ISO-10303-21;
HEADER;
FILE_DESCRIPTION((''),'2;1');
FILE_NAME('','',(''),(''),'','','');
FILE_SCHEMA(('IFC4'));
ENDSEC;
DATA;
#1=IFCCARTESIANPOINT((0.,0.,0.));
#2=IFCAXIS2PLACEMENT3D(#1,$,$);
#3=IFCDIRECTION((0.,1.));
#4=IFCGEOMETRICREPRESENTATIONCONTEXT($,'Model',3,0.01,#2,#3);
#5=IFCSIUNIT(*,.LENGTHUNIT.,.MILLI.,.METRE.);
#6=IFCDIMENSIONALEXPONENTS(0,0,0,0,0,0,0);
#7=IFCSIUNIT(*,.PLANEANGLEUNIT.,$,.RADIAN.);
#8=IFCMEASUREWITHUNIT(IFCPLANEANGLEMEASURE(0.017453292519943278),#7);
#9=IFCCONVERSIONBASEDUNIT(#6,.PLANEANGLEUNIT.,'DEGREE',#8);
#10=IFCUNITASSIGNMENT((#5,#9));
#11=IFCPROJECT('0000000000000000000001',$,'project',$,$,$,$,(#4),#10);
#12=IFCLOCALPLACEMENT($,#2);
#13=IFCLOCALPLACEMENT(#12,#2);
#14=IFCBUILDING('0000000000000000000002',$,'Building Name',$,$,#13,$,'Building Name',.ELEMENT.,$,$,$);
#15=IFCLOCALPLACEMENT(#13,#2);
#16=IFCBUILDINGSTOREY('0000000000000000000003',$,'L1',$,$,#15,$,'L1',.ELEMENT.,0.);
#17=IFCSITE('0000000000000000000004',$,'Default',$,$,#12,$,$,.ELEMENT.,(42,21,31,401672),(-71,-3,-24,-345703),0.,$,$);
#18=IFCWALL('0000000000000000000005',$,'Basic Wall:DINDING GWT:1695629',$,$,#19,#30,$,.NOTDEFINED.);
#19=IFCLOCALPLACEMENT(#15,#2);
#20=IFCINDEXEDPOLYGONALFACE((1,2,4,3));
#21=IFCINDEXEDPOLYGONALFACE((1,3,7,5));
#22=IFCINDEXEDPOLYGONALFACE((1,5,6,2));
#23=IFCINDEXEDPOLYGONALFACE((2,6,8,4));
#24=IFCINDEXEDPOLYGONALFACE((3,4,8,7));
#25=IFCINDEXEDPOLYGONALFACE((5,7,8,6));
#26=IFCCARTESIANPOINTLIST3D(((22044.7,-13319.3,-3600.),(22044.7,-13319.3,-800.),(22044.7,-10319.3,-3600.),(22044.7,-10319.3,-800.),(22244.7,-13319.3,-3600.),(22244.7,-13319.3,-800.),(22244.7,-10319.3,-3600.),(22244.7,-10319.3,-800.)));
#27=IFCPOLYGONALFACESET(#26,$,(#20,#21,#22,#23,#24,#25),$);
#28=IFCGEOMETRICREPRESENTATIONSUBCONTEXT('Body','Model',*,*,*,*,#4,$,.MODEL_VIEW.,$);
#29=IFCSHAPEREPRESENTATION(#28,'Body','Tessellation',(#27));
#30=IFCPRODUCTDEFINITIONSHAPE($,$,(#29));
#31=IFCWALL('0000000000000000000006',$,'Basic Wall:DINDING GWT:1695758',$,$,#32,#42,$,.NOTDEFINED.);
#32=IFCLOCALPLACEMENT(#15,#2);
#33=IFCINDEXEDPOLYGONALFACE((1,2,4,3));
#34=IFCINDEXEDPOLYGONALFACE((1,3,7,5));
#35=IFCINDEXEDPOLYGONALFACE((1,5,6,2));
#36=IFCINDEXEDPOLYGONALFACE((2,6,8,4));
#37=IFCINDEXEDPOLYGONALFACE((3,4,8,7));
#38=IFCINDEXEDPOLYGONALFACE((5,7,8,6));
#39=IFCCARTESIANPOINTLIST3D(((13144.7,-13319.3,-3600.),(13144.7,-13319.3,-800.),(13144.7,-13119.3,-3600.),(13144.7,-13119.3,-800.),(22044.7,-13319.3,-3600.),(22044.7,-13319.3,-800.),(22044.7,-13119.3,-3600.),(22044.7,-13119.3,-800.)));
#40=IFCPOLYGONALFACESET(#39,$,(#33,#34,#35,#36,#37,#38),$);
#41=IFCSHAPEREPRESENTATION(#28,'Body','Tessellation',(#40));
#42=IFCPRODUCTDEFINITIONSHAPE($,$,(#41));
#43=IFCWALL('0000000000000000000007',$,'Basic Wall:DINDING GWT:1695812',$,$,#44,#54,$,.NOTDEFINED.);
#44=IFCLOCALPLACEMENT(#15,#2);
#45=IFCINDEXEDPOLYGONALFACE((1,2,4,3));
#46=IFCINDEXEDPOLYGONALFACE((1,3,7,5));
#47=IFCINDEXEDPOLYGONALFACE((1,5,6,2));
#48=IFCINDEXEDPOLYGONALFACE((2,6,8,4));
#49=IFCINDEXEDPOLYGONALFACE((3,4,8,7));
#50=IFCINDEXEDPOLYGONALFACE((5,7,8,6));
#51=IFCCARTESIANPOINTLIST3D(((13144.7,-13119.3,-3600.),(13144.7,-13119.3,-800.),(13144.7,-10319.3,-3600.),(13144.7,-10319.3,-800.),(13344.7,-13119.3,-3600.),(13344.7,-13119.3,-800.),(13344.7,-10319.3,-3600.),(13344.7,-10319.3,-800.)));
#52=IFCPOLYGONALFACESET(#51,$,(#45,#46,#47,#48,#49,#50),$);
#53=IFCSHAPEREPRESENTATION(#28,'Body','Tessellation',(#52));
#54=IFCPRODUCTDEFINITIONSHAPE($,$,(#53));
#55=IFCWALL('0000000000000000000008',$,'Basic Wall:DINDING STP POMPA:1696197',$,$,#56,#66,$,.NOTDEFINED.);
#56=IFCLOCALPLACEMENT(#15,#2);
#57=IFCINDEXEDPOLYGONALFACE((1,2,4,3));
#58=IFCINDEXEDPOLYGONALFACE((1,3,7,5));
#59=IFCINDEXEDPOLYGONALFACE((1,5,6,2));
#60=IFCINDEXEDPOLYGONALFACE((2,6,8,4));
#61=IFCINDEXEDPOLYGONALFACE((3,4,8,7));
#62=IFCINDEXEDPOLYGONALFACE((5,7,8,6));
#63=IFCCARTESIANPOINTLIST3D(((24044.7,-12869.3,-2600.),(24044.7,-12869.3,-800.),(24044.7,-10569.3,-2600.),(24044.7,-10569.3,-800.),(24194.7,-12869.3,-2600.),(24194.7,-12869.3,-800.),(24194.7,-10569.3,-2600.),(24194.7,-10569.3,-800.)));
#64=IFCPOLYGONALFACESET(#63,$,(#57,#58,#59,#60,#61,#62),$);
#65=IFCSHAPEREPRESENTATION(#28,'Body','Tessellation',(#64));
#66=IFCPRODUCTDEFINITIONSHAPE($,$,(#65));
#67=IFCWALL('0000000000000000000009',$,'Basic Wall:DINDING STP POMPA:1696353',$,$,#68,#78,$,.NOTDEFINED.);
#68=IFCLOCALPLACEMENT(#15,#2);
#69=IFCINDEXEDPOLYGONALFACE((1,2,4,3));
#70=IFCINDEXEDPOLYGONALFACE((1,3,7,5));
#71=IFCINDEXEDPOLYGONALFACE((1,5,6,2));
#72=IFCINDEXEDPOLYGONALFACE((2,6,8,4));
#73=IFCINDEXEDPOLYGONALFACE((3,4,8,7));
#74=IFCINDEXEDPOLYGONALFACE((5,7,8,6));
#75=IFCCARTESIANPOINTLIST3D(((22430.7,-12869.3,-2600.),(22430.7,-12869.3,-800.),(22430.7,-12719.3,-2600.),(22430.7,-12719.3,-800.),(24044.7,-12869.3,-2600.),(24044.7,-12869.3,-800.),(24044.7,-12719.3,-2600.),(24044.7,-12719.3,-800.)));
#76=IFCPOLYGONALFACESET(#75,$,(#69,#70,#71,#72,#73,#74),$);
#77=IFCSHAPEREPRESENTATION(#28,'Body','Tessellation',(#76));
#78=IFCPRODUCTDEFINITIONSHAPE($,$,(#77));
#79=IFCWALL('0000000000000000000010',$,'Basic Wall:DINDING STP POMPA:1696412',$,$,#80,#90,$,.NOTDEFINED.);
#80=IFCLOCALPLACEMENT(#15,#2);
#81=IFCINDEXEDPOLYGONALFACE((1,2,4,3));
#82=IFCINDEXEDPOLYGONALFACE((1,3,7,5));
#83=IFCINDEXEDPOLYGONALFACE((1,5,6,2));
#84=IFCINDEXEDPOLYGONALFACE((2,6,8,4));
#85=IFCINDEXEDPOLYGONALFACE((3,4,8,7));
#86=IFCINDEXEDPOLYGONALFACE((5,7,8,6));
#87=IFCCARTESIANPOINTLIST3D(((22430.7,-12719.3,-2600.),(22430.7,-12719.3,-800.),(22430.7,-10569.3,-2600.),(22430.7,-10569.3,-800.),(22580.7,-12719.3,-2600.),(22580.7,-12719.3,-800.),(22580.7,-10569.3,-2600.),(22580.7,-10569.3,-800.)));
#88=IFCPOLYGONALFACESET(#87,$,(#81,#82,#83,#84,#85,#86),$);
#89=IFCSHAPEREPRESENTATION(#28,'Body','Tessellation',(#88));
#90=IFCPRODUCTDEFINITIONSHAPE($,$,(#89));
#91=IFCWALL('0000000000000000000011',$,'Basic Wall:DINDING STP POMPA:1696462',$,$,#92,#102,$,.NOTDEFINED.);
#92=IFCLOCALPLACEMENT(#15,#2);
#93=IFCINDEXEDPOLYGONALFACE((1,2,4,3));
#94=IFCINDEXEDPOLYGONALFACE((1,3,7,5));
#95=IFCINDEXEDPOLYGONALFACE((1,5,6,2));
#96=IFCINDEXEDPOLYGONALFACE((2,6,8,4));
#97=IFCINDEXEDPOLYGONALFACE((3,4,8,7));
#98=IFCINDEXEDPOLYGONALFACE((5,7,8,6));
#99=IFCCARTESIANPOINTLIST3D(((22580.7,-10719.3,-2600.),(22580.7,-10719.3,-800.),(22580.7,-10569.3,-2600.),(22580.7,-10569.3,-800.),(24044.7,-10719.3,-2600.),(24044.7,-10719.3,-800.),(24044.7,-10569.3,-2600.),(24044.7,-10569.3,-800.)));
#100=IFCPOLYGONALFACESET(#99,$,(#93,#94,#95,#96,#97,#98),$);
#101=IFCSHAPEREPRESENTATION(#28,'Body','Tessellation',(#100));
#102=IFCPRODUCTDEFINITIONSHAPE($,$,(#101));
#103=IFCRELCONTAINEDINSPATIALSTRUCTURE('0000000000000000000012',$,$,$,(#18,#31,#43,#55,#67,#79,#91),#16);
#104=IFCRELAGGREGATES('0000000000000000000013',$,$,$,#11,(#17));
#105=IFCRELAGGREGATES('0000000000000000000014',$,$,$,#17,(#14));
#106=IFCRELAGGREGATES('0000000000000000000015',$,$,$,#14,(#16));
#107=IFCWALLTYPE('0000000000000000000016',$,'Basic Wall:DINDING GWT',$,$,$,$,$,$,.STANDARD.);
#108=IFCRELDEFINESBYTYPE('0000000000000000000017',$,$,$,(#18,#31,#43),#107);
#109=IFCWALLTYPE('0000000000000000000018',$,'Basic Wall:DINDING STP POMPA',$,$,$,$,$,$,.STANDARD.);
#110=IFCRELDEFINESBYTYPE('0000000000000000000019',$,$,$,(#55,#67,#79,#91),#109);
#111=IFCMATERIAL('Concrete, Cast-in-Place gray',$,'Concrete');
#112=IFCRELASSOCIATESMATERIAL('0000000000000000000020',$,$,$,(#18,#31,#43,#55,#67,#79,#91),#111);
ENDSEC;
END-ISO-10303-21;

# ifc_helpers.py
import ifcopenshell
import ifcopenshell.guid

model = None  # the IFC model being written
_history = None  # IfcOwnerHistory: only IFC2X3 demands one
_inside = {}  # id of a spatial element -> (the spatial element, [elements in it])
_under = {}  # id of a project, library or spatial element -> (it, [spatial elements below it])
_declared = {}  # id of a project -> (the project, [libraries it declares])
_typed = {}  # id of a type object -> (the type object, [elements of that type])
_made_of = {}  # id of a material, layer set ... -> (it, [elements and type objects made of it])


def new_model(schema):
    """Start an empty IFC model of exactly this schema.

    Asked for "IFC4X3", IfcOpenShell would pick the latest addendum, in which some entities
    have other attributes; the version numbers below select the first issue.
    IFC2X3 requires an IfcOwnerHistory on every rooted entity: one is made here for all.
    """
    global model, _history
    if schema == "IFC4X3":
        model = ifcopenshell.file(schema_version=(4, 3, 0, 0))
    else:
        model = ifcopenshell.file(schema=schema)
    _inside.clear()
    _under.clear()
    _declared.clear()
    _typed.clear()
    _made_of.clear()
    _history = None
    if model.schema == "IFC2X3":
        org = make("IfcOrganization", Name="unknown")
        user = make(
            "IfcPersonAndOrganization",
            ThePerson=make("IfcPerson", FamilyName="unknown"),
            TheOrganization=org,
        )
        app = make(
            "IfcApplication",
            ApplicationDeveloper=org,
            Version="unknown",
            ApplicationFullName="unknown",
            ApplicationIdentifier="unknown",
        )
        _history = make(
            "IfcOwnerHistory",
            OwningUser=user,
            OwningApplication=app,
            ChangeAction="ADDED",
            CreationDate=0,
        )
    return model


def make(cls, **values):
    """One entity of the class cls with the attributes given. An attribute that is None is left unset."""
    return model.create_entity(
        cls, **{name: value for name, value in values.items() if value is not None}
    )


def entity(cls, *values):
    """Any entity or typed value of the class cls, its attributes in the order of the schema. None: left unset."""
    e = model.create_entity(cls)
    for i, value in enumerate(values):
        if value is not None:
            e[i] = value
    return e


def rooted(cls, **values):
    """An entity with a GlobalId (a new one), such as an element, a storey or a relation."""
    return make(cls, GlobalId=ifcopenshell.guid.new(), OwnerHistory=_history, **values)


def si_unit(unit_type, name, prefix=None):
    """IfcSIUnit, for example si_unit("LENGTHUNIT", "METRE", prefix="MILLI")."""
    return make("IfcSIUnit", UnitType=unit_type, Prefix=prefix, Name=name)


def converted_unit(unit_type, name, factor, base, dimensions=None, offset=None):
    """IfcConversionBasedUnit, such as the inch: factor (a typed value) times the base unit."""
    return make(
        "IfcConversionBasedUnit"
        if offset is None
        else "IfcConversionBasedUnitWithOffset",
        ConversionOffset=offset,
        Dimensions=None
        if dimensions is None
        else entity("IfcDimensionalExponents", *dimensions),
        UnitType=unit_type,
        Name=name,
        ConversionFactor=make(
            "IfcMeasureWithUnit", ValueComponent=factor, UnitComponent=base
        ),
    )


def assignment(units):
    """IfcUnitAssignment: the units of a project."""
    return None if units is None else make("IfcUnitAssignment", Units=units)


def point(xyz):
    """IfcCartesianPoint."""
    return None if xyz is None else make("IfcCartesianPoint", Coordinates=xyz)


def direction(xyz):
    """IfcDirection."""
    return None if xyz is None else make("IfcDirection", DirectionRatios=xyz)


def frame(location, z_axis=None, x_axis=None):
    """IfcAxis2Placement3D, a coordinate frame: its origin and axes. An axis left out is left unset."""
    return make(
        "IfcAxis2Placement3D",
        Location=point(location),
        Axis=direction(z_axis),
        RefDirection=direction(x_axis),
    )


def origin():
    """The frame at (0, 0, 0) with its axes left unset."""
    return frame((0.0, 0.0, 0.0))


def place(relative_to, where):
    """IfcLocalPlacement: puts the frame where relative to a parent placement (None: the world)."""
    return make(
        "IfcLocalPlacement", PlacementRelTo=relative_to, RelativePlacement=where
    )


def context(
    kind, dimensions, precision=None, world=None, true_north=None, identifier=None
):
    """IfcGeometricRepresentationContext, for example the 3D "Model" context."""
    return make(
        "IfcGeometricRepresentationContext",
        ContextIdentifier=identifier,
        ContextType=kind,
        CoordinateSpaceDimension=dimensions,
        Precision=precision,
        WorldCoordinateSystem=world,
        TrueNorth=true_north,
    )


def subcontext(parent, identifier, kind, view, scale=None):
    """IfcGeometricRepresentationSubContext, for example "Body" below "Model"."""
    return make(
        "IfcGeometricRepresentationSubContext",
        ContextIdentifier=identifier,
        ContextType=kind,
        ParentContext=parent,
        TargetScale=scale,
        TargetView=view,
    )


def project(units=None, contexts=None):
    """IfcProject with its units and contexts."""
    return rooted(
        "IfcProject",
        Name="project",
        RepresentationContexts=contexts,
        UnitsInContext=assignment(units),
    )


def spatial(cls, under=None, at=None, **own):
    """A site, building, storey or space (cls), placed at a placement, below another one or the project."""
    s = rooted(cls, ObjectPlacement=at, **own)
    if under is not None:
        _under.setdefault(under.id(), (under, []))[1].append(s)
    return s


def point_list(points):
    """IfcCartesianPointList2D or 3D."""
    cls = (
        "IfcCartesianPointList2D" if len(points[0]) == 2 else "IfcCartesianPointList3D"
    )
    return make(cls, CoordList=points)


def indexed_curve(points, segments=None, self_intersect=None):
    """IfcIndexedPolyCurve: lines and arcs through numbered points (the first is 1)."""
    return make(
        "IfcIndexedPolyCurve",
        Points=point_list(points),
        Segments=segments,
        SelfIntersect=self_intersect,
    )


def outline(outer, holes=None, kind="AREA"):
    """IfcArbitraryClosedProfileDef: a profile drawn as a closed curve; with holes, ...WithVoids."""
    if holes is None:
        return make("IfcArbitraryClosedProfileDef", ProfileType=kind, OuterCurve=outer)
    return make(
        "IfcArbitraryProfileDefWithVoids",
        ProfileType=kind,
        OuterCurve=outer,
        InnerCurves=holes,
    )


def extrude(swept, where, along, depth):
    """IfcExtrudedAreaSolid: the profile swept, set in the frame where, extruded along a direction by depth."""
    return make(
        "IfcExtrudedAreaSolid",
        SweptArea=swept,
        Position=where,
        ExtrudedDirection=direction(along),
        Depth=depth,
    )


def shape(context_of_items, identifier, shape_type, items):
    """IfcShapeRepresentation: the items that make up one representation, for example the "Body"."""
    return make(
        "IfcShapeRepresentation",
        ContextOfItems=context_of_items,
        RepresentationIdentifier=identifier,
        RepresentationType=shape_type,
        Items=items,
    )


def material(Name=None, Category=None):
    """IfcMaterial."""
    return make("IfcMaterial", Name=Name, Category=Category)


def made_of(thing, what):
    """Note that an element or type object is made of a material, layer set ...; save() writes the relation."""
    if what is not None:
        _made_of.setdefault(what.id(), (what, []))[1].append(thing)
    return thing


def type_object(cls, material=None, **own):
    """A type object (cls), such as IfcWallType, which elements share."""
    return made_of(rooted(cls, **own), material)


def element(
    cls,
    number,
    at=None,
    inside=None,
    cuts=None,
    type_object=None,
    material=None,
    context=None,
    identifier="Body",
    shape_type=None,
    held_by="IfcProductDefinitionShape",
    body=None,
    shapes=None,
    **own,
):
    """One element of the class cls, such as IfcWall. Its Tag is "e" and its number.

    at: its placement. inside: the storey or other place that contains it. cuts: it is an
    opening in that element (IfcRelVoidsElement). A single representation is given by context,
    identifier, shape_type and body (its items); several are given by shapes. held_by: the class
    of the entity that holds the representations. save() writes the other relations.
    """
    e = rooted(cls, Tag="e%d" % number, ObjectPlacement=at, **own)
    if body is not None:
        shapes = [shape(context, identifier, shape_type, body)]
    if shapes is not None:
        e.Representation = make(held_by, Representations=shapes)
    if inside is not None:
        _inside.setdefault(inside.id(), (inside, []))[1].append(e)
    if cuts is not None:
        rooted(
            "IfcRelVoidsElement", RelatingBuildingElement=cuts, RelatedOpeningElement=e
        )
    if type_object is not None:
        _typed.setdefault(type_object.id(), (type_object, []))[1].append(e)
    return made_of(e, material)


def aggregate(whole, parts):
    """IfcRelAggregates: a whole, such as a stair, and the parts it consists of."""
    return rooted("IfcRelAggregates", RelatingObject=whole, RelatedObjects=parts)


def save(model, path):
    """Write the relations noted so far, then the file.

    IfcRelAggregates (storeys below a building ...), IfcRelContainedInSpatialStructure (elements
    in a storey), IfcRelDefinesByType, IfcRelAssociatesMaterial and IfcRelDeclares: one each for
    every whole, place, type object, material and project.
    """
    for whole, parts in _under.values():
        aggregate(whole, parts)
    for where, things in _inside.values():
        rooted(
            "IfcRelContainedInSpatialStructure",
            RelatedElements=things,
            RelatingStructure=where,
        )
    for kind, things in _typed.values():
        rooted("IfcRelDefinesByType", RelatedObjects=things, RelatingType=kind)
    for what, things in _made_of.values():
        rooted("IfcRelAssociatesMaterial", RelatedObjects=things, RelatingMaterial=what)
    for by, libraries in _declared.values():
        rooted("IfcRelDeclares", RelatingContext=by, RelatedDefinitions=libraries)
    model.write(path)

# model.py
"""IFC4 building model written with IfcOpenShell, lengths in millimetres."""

from ifc_helpers import new_model, entity, si_unit, converted_unit, direction, frame, origin, place, context, subcontext, project, spatial, indexed_curve, outline, extrude, material, type_object, element, save


model = new_model("IFC4")

# Units and contexts
model_context = context("Model", 3, precision=0.01, world=origin(), true_north=direction((0.0, 1.0)))
body_context = subcontext(model_context, "Body", "Model", "MODEL_VIEW")
ifc_project = project(units=[si_unit("LENGTHUNIT", "METRE", prefix="MILLI"), converted_unit("PLANEANGLEUNIT", "DEGREE", entity("IfcPlaneAngleMeasure", 0.017453292519943278), si_unit("PLANEANGLEUNIT", "RADIAN"), dimensions=[0, 0, 0, 0, 0, 0, 0])], contexts=[model_context])

# Site, building, storey
site_placement = place(None, origin())
site = spatial("IfcSite", under=ifc_project, at=site_placement, Name="Default", CompositionType="ELEMENT", RefLatitude=(42, 21, 31, 401672), RefLongitude=(-71, -3, -24, -345703), RefElevation=0.0)
building_placement = place(site_placement, origin())
building = spatial("IfcBuilding", under=site, at=building_placement, Name="Building Name", LongName="Building Name", CompositionType="ELEMENT")
storey_placement = place(building_placement, origin())
storey = spatial("IfcBuildingStorey", under=building, at=storey_placement, Name="L1", LongName="L1", CompositionType="ELEMENT", Elevation=0.0)

# Shared definitions
ifc_material = material(Name="Concrete, Cast-in-Place gray", Category="Concrete")

# Walls
wall_type_1 = type_object("IfcWallType", Name="Basic Wall:DINDING GWT", PredefinedType="STANDARD")
wall_1_placement = place(storey_placement, frame((22144.7, -10319.3, -3600.0), z_axis=(0.0, 0.0, 1.0), x_axis=(0.0, -1.0, 0.0)))
element("IfcWall", 1, at=wall_1_placement, inside=storey, type_object=wall_type_1, material=ifc_material, Name="Basic Wall:DINDING GWT:1695629", PredefinedType="NOTDEFINED", context=body_context, shape_type="SweptSolid", body=[
    extrude(outline(indexed_curve([(3000.0, 100.0), (0.0, 100.0), (0.0, -100.0), (3000.0, -100.0), (3000.0, 100.0)], self_intersect=False)), origin(), (0.0, 0.0, 1.0), 2800.0),
])
wall_2_placement = place(storey_placement, frame((22044.7, -13219.3, -3600.0), z_axis=(0.0, 0.0, 1.0), x_axis=(-1.0, 0.0, 0.0)))
element("IfcWall", 2, at=wall_2_placement, inside=storey, type_object=wall_type_1, material=ifc_material, Name="Basic Wall:DINDING GWT:1695758", PredefinedType="NOTDEFINED", context=body_context, shape_type="SweptSolid", body=[
    extrude(outline(indexed_curve([(8900.0, 100.0), (0.0, 100.0), (0.0, -100.0), (8900.0, -100.0), (8900.0, 100.0)], self_intersect=False)), origin(), (0.0, 0.0, 1.0), 2800.0),
])
wall_3_placement = place(storey_placement, frame((13244.7, -13119.3, -3600.0), z_axis=(0.0, 0.0, 1.0), x_axis=(0.0, 1.0, 0.0)))
element("IfcWall", 3, at=wall_3_placement, inside=storey, type_object=wall_type_1, material=ifc_material, Name="Basic Wall:DINDING GWT:1695812", PredefinedType="NOTDEFINED", context=body_context, shape_type="SweptSolid", body=[
    extrude(outline(indexed_curve([(2800.0, 100.0), (0.0, 100.0), (0.0, -100.0), (2800.0, -100.0), (2800.0, 100.0)], self_intersect=False)), origin(), (0.0, 0.0, 1.0), 2800.0),
])
wall_type_2 = type_object("IfcWallType", Name="Basic Wall:DINDING STP POMPA", PredefinedType="STANDARD")
wall_4_placement = place(storey_placement, frame((24119.7, -10569.3, -2600.0), z_axis=(0.0, 0.0, 1.0), x_axis=(0.0, -1.0, 0.0)))
element("IfcWall", 4, at=wall_4_placement, inside=storey, type_object=wall_type_2, material=ifc_material, Name="Basic Wall:DINDING STP POMPA:1696197", PredefinedType="NOTDEFINED", context=body_context, shape_type="SweptSolid", body=[
    extrude(outline(indexed_curve([(2300.0, 75.0), (0.0, 75.0), (0.0, -75.0), (2300.0, -75.0), (2300.0, 75.0)], self_intersect=False)), origin(), (0.0, 0.0, 1.0), 1800.0),
])
wall_5_placement = place(storey_placement, frame((24044.7, -12794.3, -2600.0), z_axis=(0.0, 0.0, 1.0), x_axis=(-1.0, 0.0, 0.0)))
element("IfcWall", 5, at=wall_5_placement, inside=storey, type_object=wall_type_2, material=ifc_material, Name="Basic Wall:DINDING STP POMPA:1696353", PredefinedType="NOTDEFINED", context=body_context, shape_type="SweptSolid", body=[
    extrude(outline(indexed_curve([(1614.0, 75.0), (0.0, 75.0), (0.0, -75.0), (1614.0, -75.0), (1614.0, 75.0)], self_intersect=False)), origin(), (0.0, 0.0, 1.0), 1800.0),
])
wall_6_placement = place(storey_placement, frame((22505.7, -12719.3, -2600.0), z_axis=(0.0, 0.0, 1.0), x_axis=(0.0, 1.0, 0.0)))
element("IfcWall", 6, at=wall_6_placement, inside=storey, type_object=wall_type_2, material=ifc_material, Name="Basic Wall:DINDING STP POMPA:1696412", PredefinedType="NOTDEFINED", context=body_context, shape_type="SweptSolid", body=[
    extrude(outline(indexed_curve([(2150.0, 75.0), (0.0, 75.0), (0.0, -75.0), (2150.0, -75.0), (2150.0, 75.0)], self_intersect=False)), origin(), (0.0, 0.0, 1.0), 1800.0),
])
wall_7_placement = place(storey_placement, frame((22580.7, -10644.3, -2600.0)))
element("IfcWall", 7, at=wall_7_placement, inside=storey, type_object=wall_type_2, material=ifc_material, Name="Basic Wall:DINDING STP POMPA:1696462", PredefinedType="NOTDEFINED", context=body_context, shape_type="SweptSolid", body=[
    extrude(outline(indexed_curve([(1464.0, 75.0), (0.0, 75.0), (0.0, -75.0), (1464.0, -75.0), (1464.0, 75.0)], self_intersect=False)), origin(), (0.0, 0.0, 1.0), 1800.0),
])

save(model, "model.ifc")
